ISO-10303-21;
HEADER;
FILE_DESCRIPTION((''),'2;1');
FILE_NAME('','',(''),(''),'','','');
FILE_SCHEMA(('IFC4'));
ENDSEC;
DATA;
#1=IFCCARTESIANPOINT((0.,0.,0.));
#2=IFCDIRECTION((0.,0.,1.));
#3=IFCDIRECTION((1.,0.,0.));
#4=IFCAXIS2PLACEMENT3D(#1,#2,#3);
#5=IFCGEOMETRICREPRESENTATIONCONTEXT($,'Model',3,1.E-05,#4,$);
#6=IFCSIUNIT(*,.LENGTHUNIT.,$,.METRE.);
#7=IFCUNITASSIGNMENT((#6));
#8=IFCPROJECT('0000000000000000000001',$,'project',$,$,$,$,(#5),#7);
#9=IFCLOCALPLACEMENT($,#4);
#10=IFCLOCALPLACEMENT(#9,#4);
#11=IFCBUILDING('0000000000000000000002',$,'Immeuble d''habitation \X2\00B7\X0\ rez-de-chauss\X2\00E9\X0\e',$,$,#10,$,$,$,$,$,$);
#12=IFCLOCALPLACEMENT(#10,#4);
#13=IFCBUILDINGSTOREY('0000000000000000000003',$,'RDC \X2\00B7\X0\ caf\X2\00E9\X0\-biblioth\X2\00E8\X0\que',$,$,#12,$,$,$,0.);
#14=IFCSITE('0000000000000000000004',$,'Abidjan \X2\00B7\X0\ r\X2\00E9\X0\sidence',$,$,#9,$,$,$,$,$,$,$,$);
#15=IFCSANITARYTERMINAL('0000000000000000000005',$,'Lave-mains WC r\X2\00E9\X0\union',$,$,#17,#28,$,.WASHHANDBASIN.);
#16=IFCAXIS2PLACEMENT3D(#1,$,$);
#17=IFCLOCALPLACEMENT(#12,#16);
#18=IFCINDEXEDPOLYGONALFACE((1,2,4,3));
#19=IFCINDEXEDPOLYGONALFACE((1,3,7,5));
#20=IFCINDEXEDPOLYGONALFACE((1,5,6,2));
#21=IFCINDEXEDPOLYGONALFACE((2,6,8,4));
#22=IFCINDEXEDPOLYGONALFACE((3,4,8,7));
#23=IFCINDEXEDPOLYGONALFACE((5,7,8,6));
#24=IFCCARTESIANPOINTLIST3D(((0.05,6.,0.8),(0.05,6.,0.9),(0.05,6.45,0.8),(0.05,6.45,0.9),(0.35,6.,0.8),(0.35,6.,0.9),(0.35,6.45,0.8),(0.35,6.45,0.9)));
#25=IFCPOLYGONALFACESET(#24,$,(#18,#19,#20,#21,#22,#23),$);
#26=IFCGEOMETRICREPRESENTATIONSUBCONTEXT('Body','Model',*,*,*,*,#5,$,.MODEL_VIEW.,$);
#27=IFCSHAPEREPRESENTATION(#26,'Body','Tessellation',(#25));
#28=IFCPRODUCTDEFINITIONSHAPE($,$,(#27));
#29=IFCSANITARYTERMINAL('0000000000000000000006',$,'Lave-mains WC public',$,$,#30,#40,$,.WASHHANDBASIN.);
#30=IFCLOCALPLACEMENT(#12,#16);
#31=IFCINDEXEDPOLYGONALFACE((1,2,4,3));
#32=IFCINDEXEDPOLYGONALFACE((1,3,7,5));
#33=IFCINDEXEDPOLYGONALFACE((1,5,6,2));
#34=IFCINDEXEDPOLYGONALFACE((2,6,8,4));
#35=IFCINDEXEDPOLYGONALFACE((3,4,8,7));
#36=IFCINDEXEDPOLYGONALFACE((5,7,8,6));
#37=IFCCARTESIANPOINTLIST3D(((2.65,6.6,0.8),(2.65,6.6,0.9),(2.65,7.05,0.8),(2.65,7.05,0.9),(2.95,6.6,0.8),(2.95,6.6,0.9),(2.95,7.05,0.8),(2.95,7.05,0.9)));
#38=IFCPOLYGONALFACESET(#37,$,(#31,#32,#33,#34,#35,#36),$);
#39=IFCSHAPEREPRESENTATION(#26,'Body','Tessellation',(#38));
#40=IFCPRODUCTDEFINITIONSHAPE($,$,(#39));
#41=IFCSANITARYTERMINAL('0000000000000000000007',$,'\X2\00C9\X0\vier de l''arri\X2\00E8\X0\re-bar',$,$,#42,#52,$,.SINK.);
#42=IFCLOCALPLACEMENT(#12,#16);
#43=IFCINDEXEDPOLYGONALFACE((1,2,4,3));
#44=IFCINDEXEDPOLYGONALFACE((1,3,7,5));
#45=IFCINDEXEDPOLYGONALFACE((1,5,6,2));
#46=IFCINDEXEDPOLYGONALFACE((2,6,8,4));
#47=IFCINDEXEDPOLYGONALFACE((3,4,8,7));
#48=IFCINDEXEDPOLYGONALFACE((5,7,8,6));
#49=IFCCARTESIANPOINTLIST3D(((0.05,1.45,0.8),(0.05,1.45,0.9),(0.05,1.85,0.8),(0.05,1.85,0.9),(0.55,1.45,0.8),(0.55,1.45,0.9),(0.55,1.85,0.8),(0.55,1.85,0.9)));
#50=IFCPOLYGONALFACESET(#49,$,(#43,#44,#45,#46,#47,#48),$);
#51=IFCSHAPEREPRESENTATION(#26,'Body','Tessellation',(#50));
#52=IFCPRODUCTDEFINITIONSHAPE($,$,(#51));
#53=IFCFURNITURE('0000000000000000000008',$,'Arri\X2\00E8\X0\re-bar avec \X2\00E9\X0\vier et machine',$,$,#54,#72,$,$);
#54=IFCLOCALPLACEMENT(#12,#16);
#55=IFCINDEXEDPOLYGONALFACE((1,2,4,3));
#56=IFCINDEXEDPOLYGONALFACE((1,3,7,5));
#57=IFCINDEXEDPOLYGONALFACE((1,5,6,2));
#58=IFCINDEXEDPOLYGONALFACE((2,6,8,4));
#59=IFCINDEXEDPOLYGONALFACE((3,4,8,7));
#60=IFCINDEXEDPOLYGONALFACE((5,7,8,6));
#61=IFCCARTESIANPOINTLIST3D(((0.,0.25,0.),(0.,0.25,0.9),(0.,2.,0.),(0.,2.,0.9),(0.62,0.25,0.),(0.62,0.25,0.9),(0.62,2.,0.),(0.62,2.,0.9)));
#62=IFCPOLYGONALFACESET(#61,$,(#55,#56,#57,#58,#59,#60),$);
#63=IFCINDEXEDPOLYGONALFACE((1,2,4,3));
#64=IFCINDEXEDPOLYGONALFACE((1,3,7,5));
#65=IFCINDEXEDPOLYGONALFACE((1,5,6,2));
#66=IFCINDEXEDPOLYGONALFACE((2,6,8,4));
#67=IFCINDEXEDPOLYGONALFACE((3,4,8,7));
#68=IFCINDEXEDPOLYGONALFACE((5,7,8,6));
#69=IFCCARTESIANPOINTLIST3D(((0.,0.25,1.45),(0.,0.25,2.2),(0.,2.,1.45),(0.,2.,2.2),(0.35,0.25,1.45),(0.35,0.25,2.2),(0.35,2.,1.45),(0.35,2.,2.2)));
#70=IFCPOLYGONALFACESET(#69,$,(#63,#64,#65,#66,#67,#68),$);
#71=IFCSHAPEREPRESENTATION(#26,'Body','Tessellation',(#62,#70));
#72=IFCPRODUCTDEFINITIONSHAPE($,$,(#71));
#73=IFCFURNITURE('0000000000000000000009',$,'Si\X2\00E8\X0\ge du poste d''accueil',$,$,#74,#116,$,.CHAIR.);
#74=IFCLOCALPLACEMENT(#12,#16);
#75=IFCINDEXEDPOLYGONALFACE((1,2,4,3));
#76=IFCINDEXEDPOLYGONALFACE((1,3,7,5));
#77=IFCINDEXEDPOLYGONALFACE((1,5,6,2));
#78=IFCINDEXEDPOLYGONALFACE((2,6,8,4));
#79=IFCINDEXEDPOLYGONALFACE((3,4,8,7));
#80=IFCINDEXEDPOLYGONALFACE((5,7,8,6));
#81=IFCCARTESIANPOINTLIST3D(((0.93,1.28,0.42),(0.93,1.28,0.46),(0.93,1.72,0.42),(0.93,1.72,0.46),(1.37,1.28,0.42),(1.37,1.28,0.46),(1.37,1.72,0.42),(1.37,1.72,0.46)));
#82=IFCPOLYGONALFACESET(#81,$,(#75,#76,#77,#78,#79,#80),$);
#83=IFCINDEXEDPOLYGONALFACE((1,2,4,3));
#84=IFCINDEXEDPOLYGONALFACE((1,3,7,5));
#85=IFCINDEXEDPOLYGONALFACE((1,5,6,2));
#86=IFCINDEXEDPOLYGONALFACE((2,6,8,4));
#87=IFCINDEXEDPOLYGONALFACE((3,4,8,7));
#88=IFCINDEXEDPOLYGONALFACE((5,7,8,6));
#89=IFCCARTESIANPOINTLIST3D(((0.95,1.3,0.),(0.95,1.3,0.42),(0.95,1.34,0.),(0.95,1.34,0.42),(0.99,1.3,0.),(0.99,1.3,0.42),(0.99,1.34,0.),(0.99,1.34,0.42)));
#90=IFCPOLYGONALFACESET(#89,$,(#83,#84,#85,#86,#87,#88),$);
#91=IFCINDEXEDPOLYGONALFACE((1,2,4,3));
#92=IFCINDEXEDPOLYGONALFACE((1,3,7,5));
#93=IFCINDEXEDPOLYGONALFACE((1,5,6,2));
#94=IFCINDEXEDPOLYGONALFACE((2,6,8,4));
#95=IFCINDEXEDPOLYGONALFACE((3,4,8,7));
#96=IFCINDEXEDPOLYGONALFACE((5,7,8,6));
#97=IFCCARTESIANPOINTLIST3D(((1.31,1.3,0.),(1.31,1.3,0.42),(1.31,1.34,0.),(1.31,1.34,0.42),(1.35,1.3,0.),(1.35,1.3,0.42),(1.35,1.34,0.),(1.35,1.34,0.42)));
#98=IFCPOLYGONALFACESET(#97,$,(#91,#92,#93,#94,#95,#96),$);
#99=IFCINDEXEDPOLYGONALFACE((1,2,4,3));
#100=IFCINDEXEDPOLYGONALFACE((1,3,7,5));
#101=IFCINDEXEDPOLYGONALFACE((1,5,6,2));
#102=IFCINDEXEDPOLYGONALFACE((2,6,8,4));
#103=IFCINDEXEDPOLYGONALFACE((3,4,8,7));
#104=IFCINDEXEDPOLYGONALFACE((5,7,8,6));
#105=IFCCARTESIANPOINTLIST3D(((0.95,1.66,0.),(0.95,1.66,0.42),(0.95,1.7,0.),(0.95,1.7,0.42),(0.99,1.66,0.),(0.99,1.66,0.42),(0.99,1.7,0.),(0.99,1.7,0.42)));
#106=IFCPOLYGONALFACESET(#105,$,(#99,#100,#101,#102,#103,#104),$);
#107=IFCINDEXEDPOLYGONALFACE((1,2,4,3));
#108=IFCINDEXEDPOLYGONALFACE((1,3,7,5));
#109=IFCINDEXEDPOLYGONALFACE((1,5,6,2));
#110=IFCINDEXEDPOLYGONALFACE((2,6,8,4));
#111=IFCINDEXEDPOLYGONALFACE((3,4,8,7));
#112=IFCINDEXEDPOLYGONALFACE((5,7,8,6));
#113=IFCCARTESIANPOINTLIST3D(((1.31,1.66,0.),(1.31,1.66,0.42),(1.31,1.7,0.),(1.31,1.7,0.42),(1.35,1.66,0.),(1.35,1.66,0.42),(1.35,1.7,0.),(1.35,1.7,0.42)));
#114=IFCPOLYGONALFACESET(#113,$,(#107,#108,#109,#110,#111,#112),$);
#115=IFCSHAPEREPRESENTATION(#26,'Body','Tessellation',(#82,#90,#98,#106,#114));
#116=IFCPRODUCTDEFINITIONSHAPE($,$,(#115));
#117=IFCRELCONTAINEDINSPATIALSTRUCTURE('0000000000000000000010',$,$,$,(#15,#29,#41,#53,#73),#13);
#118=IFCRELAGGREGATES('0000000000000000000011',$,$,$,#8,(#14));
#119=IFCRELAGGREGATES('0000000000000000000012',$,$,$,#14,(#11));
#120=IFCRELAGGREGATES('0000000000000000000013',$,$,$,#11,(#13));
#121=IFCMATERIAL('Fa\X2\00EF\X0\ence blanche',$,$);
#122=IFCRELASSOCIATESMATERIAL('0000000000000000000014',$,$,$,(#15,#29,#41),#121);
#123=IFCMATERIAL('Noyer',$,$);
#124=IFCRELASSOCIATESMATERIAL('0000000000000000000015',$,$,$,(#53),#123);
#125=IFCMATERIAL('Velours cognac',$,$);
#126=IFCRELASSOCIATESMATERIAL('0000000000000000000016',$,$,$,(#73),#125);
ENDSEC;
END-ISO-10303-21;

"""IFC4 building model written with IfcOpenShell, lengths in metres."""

from ifc_helpers import new_model, si_unit, frame, frame_2d, origin, origin_with_axes, place, context, subcontext, project, spatial, rectangle, extrude, material, element, save


model = new_model("IFC4")

# Units and contexts
model_context = context("Model", 3, precision=1e-05, world=origin_with_axes())
body_context = subcontext(model_context, "Body", "Model", "MODEL_VIEW")
ifc_project = project(units=[si_unit("LENGTHUNIT", "METRE")], contexts=[model_context])

# Site, building, storey
site_placement = place(None, origin_with_axes())
site = spatial("IfcSite", under=ifc_project, at=site_placement, Name="Abidjan · résidence")
building_placement = place(site_placement, origin_with_axes())
building = spatial("IfcBuilding", under=site, at=building_placement, Name="Immeuble d'habitation · rez-de-chaussée")
storey_placement = place(building_placement, origin_with_axes())
storey = spatial("IfcBuildingStorey", under=building, at=storey_placement, Name="RDC · café-bibliothèque", Elevation=0.0)

# Shared definitions
ifc_material_1 = material(Name="Noyer")

# Sanitary terminals
ifc_material_2 = material(Name="Faïence blanche")
sanitary_terminal_1_placement = place(storey_placement, origin_with_axes())
element("IfcSanitaryTerminal", 1, at=sanitary_terminal_1_placement, inside=storey, material=ifc_material_2, Name="Lave-mains WC réunion", PredefinedType="WASHHANDBASIN", context=body_context, shape_type="SweptSolid", body=[
    extrude(rectangle(XDim=0.3, YDim=0.45, at=frame_2d((0.2, 6.225))), frame((0.0, 0.0, 0.8)), (0.0, 0.0, 1.0), 0.1),
])
sanitary_terminal_2_placement = place(storey_placement, origin_with_axes())
element("IfcSanitaryTerminal", 2, at=sanitary_terminal_2_placement, inside=storey, material=ifc_material_2, Name="Lave-mains WC public", PredefinedType="WASHHANDBASIN", context=body_context, shape_type="SweptSolid", body=[
    extrude(rectangle(XDim=0.3, YDim=0.45, at=frame_2d((2.8, 6.825))), frame((0.0, 0.0, 0.8)), (0.0, 0.0, 1.0), 0.1),
])
sanitary_terminal_3_placement = place(storey_placement, origin_with_axes())
element("IfcSanitaryTerminal", 3, at=sanitary_terminal_3_placement, inside=storey, material=ifc_material_2, Name="Évier de l'arrière-bar", PredefinedType="SINK", context=body_context, shape_type="SweptSolid", body=[
    extrude(rectangle(XDim=0.5, YDim=0.4, at=frame_2d((0.3, 1.65))), frame((0.0, 0.0, 0.8)), (0.0, 0.0, 1.0), 0.1),
])

# Furniture
furniture_1_placement = place(storey_placement, origin_with_axes())
element("IfcFurniture", 4, at=furniture_1_placement, inside=storey, material=ifc_material_1, Name="Arrière-bar avec évier et machine", context=body_context, shape_type="SweptSolid", body=[
    extrude(rectangle(XDim=0.62, YDim=1.75, at=frame_2d((0.31, 1.125))), origin(), (0.0, 0.0, 1.0), 0.9),
    extrude(rectangle(XDim=0.35, YDim=1.75, at=frame_2d((0.175, 1.125))), frame((0.0, 0.0, 1.45)), (0.0, 0.0, 1.0), 0.75),
])
ifc_material_3 = material(Name="Velours cognac")
furniture_2_placement = place(storey_placement, origin_with_axes())
element("IfcFurniture", 5, at=furniture_2_placement, inside=storey, material=ifc_material_3, Name="Siège du poste d'accueil", PredefinedType="CHAIR", context=body_context, shape_type="SweptSolid", body=[
    extrude(rectangle(XDim=0.44, YDim=0.44, at=frame_2d((1.15, 1.5))), frame((0.0, 0.0, 0.42)), (0.0, 0.0, 1.0), 0.04),
    extrude(rectangle(XDim=0.04, YDim=0.04, at=frame_2d((0.97, 1.32))), origin(), (0.0, 0.0, 1.0), 0.42),
    extrude(rectangle(XDim=0.04, YDim=0.04, at=frame_2d((1.33, 1.32))), origin(), (0.0, 0.0, 1.0), 0.42),
    extrude(rectangle(XDim=0.04, YDim=0.04, at=frame_2d((0.97, 1.68))), origin(), (0.0, 0.0, 1.0), 0.42),
    extrude(rectangle(XDim=0.04, YDim=0.04, at=frame_2d((1.33, 1.68))), origin(), (0.0, 0.0, 1.0), 0.42),
])

save(model, "model.ifc")
